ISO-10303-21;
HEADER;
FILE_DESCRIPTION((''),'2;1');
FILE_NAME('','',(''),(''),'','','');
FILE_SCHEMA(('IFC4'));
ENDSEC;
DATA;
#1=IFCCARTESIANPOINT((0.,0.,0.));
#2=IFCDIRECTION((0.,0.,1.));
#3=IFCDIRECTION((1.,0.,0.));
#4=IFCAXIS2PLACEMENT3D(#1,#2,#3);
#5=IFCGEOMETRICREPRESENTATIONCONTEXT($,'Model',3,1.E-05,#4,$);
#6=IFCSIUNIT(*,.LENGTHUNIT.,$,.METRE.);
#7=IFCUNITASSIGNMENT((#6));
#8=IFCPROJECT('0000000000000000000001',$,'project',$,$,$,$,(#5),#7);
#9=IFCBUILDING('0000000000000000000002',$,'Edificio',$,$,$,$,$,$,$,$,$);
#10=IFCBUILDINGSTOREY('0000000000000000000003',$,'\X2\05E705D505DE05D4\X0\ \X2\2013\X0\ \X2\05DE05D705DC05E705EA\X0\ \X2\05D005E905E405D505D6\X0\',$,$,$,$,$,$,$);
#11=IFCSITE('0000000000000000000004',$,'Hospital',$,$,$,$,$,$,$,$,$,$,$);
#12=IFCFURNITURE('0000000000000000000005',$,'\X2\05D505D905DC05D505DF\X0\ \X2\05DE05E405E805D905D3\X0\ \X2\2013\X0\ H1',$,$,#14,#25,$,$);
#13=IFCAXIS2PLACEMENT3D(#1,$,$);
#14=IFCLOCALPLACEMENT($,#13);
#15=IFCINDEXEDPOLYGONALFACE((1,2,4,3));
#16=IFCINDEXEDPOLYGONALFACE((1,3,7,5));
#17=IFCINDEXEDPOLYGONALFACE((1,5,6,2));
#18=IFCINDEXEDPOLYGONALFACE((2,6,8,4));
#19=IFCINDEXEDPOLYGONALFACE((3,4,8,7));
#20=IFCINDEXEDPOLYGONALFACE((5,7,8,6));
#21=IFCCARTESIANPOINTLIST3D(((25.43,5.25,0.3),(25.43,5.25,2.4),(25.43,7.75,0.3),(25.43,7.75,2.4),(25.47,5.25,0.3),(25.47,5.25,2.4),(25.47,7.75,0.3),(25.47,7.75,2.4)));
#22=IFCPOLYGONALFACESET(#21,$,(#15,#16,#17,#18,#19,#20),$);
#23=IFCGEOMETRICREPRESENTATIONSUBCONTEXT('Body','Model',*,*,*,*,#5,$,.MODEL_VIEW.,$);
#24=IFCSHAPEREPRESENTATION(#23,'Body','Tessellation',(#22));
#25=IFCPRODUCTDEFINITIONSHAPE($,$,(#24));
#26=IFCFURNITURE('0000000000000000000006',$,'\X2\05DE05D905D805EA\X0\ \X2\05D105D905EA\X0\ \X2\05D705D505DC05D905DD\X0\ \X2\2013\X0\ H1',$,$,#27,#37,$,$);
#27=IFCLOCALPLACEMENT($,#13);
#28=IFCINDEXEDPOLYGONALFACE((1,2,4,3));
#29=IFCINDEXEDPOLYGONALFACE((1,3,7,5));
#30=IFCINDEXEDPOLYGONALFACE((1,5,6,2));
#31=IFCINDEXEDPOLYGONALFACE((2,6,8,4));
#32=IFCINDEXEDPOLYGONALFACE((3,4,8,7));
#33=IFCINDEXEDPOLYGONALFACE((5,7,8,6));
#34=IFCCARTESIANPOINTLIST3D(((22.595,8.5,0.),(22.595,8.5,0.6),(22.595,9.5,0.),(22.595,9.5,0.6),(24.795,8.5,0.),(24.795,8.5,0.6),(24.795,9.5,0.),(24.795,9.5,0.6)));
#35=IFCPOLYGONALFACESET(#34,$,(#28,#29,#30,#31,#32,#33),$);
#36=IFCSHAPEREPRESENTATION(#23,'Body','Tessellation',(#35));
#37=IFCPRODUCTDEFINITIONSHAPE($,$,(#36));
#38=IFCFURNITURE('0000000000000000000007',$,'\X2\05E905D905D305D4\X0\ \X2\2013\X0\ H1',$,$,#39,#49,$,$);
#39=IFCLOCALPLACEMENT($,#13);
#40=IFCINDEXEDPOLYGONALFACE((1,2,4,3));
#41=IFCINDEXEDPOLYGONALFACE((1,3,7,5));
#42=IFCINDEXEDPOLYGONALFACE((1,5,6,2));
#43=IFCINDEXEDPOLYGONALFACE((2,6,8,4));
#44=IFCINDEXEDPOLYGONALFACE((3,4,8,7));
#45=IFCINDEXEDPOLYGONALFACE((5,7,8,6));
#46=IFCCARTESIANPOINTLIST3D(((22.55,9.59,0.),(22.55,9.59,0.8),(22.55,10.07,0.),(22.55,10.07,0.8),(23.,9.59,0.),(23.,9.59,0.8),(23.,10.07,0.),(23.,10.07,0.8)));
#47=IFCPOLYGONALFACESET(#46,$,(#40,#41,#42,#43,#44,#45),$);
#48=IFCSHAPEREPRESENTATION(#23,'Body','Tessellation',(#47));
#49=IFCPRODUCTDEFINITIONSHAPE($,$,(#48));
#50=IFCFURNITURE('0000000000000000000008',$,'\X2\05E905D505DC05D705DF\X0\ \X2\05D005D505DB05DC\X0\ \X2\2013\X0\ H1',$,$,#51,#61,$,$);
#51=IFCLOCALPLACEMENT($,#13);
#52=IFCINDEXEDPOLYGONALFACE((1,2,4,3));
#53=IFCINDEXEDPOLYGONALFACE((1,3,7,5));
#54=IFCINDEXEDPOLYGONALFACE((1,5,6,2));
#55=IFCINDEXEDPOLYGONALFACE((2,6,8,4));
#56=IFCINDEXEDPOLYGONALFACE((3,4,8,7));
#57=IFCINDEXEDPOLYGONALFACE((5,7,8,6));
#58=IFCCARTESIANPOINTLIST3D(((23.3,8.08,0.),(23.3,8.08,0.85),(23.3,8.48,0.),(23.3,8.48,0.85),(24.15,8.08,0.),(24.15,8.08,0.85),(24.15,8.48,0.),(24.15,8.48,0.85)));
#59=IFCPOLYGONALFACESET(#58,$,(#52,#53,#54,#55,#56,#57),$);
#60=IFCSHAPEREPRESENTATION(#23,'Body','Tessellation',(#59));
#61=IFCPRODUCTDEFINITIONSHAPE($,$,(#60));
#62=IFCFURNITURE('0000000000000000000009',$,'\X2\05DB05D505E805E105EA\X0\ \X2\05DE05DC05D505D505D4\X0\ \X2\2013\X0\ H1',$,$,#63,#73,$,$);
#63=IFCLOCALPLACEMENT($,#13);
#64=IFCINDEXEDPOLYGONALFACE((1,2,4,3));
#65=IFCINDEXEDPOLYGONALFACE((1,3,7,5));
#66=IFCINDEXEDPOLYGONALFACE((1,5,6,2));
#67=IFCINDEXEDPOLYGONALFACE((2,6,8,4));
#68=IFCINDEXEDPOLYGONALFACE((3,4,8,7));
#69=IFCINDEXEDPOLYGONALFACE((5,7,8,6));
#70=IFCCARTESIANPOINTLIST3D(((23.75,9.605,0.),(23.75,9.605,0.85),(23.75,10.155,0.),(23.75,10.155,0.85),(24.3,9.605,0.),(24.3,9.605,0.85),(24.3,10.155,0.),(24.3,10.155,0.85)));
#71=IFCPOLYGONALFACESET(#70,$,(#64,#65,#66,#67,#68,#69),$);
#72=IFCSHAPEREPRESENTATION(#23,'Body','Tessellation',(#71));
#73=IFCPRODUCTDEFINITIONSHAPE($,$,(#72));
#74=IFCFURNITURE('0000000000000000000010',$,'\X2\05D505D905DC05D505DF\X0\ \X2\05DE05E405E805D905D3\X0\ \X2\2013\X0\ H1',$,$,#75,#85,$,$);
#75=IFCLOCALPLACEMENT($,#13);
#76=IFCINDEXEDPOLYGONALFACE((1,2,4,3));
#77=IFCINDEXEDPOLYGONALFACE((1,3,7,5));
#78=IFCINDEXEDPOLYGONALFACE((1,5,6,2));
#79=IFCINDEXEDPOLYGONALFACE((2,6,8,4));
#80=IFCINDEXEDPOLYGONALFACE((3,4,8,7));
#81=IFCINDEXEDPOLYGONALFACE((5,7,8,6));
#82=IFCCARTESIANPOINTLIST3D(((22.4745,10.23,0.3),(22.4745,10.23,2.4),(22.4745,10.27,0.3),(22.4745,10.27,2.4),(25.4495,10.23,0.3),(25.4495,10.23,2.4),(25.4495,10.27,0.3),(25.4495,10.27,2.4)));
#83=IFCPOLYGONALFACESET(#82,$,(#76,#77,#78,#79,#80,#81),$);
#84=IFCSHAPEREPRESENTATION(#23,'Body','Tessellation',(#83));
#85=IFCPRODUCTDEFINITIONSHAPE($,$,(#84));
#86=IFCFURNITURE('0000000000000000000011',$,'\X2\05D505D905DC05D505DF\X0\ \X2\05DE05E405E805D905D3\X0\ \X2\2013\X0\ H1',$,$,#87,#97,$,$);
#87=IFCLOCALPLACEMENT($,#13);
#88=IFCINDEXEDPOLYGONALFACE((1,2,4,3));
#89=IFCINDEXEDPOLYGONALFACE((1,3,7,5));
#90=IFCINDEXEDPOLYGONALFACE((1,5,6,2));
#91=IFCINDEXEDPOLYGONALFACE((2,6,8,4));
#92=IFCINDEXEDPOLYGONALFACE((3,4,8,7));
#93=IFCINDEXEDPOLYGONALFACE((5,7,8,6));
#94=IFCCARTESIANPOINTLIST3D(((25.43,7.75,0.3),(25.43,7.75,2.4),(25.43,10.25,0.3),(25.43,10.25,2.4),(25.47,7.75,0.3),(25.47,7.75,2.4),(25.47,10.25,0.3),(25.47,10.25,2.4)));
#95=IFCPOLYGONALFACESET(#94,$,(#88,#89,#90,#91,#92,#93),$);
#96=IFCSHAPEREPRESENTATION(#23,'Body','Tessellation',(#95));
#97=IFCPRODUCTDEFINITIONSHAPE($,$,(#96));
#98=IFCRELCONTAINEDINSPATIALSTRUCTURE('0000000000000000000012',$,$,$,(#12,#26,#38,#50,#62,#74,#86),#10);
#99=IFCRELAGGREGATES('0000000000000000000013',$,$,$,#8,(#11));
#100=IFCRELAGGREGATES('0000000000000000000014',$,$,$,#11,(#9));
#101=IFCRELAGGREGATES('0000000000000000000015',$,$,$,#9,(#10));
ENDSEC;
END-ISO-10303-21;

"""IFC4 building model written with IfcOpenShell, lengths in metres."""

from ifc_helpers import new_model, si_unit, frame, origin_with_axes, context, subcontext, project, spatial, line, indexed_curve, outline, extrude, element, save


model = new_model("IFC4")

# Units and contexts
model_context = context("Model", 3, precision=1e-05, world=origin_with_axes())
body_context = subcontext(model_context, "Body", "Model", "MODEL_VIEW")
ifc_project = project(units=[si_unit("LENGTHUNIT", "METRE")], contexts=[model_context])

# Site, building, storey
site = spatial("IfcSite", under=ifc_project, Name="Hospital")
building = spatial("IfcBuilding", under=site, Name="Edificio")
storey = spatial("IfcBuildingStorey", under=building, Name="קומה – מחלקת אשפוז")

# Furniture
element("IfcFurniture", 1, inside=storey, Name="וילון מפריד – H1", context=body_context, shape_type="SweptSolid", body=[
    extrude(outline(indexed_curve([(0.0, 0.0), (0.04, 0.0), (0.04, 2.5), (0.0, 2.5)], segments=[line(1, 2, 3, 4, 1)])), frame((25.43, 5.25, 0.3), z_axis=(0.0, 0.0, 1.0), x_axis=(1.0, 0.0, 0.0)), (0.0, 0.0, 1.0), 2.1),
])
element("IfcFurniture", 2, inside=storey, Name="מיטת בית חולים – H1", context=body_context, shape_type="SweptSolid", body=[
    extrude(outline(indexed_curve([(0.0, 0.0), (2.2, 0.0), (2.2, 1.0), (0.0, 1.0)], segments=[line(1, 2, 3, 4, 1)])), frame((22.595, 8.5, 0.0), z_axis=(0.0, 0.0, 1.0), x_axis=(1.0, 0.0, 0.0)), (0.0, 0.0, 1.0), 0.6),
])
element("IfcFurniture", 3, inside=storey, Name="שידה – H1", context=body_context, shape_type="SweptSolid", body=[
    extrude(outline(indexed_curve([(0.0, 0.0), (0.45, 0.0), (0.45, 0.48), (0.0, 0.48)], segments=[line(1, 2, 3, 4, 1)])), frame((22.55, 9.59, 0.0), z_axis=(0.0, 0.0, 1.0), x_axis=(1.0, 0.0, 0.0)), (0.0, 0.0, 1.0), 0.8),
])
element("IfcFurniture", 4, inside=storey, Name="שולחן אוכל – H1", context=body_context, shape_type="SweptSolid", body=[
    extrude(outline(indexed_curve([(0.0, 0.0), (0.85, 0.0), (0.85, 0.4), (0.0, 0.4)], segments=[line(1, 2, 3, 4, 1)])), frame((23.3, 8.08, 0.0), z_axis=(0.0, 0.0, 1.0), x_axis=(1.0, 0.0, 0.0)), (0.0, 0.0, 1.0), 0.85),
])
element("IfcFurniture", 5, inside=storey, Name="כורסת מלווה – H1", context=body_context, shape_type="SweptSolid", body=[
    extrude(outline(indexed_curve([(0.0, 0.0), (0.55, 0.0), (0.55, 0.55), (0.0, 0.55)], segments=[line(1, 2, 3, 4, 1)])), frame((23.75, 9.605, 0.0), z_axis=(0.0, 0.0, 1.0), x_axis=(1.0, 0.0, 0.0)), (0.0, 0.0, 1.0), 0.85),
])
element("IfcFurniture", 6, inside=storey, Name="וילון מפריד – H1", context=body_context, shape_type="SweptSolid", body=[
    extrude(outline(indexed_curve([(0.0, 0.0), (2.975, 0.0), (2.975, 0.04), (0.0, 0.04)], segments=[line(1, 2, 3, 4, 1)])), frame((22.4745, 10.23, 0.3), z_axis=(0.0, 0.0, 1.0), x_axis=(1.0, 0.0, 0.0)), (0.0, 0.0, 1.0), 2.1),
])
element("IfcFurniture", 7, inside=storey, Name="וילון מפריד – H1", context=body_context, shape_type="SweptSolid", body=[
    extrude(outline(indexed_curve([(0.0, 0.0), (0.04, 0.0), (0.04, 2.5), (0.0, 2.5)], segments=[line(1, 2, 3, 4, 1)])), frame((25.43, 7.75, 0.3), z_axis=(0.0, 0.0, 1.0), x_axis=(1.0, 0.0, 0.0)), (0.0, 0.0, 1.0), 2.1),
])

save(model, "model.ifc")
